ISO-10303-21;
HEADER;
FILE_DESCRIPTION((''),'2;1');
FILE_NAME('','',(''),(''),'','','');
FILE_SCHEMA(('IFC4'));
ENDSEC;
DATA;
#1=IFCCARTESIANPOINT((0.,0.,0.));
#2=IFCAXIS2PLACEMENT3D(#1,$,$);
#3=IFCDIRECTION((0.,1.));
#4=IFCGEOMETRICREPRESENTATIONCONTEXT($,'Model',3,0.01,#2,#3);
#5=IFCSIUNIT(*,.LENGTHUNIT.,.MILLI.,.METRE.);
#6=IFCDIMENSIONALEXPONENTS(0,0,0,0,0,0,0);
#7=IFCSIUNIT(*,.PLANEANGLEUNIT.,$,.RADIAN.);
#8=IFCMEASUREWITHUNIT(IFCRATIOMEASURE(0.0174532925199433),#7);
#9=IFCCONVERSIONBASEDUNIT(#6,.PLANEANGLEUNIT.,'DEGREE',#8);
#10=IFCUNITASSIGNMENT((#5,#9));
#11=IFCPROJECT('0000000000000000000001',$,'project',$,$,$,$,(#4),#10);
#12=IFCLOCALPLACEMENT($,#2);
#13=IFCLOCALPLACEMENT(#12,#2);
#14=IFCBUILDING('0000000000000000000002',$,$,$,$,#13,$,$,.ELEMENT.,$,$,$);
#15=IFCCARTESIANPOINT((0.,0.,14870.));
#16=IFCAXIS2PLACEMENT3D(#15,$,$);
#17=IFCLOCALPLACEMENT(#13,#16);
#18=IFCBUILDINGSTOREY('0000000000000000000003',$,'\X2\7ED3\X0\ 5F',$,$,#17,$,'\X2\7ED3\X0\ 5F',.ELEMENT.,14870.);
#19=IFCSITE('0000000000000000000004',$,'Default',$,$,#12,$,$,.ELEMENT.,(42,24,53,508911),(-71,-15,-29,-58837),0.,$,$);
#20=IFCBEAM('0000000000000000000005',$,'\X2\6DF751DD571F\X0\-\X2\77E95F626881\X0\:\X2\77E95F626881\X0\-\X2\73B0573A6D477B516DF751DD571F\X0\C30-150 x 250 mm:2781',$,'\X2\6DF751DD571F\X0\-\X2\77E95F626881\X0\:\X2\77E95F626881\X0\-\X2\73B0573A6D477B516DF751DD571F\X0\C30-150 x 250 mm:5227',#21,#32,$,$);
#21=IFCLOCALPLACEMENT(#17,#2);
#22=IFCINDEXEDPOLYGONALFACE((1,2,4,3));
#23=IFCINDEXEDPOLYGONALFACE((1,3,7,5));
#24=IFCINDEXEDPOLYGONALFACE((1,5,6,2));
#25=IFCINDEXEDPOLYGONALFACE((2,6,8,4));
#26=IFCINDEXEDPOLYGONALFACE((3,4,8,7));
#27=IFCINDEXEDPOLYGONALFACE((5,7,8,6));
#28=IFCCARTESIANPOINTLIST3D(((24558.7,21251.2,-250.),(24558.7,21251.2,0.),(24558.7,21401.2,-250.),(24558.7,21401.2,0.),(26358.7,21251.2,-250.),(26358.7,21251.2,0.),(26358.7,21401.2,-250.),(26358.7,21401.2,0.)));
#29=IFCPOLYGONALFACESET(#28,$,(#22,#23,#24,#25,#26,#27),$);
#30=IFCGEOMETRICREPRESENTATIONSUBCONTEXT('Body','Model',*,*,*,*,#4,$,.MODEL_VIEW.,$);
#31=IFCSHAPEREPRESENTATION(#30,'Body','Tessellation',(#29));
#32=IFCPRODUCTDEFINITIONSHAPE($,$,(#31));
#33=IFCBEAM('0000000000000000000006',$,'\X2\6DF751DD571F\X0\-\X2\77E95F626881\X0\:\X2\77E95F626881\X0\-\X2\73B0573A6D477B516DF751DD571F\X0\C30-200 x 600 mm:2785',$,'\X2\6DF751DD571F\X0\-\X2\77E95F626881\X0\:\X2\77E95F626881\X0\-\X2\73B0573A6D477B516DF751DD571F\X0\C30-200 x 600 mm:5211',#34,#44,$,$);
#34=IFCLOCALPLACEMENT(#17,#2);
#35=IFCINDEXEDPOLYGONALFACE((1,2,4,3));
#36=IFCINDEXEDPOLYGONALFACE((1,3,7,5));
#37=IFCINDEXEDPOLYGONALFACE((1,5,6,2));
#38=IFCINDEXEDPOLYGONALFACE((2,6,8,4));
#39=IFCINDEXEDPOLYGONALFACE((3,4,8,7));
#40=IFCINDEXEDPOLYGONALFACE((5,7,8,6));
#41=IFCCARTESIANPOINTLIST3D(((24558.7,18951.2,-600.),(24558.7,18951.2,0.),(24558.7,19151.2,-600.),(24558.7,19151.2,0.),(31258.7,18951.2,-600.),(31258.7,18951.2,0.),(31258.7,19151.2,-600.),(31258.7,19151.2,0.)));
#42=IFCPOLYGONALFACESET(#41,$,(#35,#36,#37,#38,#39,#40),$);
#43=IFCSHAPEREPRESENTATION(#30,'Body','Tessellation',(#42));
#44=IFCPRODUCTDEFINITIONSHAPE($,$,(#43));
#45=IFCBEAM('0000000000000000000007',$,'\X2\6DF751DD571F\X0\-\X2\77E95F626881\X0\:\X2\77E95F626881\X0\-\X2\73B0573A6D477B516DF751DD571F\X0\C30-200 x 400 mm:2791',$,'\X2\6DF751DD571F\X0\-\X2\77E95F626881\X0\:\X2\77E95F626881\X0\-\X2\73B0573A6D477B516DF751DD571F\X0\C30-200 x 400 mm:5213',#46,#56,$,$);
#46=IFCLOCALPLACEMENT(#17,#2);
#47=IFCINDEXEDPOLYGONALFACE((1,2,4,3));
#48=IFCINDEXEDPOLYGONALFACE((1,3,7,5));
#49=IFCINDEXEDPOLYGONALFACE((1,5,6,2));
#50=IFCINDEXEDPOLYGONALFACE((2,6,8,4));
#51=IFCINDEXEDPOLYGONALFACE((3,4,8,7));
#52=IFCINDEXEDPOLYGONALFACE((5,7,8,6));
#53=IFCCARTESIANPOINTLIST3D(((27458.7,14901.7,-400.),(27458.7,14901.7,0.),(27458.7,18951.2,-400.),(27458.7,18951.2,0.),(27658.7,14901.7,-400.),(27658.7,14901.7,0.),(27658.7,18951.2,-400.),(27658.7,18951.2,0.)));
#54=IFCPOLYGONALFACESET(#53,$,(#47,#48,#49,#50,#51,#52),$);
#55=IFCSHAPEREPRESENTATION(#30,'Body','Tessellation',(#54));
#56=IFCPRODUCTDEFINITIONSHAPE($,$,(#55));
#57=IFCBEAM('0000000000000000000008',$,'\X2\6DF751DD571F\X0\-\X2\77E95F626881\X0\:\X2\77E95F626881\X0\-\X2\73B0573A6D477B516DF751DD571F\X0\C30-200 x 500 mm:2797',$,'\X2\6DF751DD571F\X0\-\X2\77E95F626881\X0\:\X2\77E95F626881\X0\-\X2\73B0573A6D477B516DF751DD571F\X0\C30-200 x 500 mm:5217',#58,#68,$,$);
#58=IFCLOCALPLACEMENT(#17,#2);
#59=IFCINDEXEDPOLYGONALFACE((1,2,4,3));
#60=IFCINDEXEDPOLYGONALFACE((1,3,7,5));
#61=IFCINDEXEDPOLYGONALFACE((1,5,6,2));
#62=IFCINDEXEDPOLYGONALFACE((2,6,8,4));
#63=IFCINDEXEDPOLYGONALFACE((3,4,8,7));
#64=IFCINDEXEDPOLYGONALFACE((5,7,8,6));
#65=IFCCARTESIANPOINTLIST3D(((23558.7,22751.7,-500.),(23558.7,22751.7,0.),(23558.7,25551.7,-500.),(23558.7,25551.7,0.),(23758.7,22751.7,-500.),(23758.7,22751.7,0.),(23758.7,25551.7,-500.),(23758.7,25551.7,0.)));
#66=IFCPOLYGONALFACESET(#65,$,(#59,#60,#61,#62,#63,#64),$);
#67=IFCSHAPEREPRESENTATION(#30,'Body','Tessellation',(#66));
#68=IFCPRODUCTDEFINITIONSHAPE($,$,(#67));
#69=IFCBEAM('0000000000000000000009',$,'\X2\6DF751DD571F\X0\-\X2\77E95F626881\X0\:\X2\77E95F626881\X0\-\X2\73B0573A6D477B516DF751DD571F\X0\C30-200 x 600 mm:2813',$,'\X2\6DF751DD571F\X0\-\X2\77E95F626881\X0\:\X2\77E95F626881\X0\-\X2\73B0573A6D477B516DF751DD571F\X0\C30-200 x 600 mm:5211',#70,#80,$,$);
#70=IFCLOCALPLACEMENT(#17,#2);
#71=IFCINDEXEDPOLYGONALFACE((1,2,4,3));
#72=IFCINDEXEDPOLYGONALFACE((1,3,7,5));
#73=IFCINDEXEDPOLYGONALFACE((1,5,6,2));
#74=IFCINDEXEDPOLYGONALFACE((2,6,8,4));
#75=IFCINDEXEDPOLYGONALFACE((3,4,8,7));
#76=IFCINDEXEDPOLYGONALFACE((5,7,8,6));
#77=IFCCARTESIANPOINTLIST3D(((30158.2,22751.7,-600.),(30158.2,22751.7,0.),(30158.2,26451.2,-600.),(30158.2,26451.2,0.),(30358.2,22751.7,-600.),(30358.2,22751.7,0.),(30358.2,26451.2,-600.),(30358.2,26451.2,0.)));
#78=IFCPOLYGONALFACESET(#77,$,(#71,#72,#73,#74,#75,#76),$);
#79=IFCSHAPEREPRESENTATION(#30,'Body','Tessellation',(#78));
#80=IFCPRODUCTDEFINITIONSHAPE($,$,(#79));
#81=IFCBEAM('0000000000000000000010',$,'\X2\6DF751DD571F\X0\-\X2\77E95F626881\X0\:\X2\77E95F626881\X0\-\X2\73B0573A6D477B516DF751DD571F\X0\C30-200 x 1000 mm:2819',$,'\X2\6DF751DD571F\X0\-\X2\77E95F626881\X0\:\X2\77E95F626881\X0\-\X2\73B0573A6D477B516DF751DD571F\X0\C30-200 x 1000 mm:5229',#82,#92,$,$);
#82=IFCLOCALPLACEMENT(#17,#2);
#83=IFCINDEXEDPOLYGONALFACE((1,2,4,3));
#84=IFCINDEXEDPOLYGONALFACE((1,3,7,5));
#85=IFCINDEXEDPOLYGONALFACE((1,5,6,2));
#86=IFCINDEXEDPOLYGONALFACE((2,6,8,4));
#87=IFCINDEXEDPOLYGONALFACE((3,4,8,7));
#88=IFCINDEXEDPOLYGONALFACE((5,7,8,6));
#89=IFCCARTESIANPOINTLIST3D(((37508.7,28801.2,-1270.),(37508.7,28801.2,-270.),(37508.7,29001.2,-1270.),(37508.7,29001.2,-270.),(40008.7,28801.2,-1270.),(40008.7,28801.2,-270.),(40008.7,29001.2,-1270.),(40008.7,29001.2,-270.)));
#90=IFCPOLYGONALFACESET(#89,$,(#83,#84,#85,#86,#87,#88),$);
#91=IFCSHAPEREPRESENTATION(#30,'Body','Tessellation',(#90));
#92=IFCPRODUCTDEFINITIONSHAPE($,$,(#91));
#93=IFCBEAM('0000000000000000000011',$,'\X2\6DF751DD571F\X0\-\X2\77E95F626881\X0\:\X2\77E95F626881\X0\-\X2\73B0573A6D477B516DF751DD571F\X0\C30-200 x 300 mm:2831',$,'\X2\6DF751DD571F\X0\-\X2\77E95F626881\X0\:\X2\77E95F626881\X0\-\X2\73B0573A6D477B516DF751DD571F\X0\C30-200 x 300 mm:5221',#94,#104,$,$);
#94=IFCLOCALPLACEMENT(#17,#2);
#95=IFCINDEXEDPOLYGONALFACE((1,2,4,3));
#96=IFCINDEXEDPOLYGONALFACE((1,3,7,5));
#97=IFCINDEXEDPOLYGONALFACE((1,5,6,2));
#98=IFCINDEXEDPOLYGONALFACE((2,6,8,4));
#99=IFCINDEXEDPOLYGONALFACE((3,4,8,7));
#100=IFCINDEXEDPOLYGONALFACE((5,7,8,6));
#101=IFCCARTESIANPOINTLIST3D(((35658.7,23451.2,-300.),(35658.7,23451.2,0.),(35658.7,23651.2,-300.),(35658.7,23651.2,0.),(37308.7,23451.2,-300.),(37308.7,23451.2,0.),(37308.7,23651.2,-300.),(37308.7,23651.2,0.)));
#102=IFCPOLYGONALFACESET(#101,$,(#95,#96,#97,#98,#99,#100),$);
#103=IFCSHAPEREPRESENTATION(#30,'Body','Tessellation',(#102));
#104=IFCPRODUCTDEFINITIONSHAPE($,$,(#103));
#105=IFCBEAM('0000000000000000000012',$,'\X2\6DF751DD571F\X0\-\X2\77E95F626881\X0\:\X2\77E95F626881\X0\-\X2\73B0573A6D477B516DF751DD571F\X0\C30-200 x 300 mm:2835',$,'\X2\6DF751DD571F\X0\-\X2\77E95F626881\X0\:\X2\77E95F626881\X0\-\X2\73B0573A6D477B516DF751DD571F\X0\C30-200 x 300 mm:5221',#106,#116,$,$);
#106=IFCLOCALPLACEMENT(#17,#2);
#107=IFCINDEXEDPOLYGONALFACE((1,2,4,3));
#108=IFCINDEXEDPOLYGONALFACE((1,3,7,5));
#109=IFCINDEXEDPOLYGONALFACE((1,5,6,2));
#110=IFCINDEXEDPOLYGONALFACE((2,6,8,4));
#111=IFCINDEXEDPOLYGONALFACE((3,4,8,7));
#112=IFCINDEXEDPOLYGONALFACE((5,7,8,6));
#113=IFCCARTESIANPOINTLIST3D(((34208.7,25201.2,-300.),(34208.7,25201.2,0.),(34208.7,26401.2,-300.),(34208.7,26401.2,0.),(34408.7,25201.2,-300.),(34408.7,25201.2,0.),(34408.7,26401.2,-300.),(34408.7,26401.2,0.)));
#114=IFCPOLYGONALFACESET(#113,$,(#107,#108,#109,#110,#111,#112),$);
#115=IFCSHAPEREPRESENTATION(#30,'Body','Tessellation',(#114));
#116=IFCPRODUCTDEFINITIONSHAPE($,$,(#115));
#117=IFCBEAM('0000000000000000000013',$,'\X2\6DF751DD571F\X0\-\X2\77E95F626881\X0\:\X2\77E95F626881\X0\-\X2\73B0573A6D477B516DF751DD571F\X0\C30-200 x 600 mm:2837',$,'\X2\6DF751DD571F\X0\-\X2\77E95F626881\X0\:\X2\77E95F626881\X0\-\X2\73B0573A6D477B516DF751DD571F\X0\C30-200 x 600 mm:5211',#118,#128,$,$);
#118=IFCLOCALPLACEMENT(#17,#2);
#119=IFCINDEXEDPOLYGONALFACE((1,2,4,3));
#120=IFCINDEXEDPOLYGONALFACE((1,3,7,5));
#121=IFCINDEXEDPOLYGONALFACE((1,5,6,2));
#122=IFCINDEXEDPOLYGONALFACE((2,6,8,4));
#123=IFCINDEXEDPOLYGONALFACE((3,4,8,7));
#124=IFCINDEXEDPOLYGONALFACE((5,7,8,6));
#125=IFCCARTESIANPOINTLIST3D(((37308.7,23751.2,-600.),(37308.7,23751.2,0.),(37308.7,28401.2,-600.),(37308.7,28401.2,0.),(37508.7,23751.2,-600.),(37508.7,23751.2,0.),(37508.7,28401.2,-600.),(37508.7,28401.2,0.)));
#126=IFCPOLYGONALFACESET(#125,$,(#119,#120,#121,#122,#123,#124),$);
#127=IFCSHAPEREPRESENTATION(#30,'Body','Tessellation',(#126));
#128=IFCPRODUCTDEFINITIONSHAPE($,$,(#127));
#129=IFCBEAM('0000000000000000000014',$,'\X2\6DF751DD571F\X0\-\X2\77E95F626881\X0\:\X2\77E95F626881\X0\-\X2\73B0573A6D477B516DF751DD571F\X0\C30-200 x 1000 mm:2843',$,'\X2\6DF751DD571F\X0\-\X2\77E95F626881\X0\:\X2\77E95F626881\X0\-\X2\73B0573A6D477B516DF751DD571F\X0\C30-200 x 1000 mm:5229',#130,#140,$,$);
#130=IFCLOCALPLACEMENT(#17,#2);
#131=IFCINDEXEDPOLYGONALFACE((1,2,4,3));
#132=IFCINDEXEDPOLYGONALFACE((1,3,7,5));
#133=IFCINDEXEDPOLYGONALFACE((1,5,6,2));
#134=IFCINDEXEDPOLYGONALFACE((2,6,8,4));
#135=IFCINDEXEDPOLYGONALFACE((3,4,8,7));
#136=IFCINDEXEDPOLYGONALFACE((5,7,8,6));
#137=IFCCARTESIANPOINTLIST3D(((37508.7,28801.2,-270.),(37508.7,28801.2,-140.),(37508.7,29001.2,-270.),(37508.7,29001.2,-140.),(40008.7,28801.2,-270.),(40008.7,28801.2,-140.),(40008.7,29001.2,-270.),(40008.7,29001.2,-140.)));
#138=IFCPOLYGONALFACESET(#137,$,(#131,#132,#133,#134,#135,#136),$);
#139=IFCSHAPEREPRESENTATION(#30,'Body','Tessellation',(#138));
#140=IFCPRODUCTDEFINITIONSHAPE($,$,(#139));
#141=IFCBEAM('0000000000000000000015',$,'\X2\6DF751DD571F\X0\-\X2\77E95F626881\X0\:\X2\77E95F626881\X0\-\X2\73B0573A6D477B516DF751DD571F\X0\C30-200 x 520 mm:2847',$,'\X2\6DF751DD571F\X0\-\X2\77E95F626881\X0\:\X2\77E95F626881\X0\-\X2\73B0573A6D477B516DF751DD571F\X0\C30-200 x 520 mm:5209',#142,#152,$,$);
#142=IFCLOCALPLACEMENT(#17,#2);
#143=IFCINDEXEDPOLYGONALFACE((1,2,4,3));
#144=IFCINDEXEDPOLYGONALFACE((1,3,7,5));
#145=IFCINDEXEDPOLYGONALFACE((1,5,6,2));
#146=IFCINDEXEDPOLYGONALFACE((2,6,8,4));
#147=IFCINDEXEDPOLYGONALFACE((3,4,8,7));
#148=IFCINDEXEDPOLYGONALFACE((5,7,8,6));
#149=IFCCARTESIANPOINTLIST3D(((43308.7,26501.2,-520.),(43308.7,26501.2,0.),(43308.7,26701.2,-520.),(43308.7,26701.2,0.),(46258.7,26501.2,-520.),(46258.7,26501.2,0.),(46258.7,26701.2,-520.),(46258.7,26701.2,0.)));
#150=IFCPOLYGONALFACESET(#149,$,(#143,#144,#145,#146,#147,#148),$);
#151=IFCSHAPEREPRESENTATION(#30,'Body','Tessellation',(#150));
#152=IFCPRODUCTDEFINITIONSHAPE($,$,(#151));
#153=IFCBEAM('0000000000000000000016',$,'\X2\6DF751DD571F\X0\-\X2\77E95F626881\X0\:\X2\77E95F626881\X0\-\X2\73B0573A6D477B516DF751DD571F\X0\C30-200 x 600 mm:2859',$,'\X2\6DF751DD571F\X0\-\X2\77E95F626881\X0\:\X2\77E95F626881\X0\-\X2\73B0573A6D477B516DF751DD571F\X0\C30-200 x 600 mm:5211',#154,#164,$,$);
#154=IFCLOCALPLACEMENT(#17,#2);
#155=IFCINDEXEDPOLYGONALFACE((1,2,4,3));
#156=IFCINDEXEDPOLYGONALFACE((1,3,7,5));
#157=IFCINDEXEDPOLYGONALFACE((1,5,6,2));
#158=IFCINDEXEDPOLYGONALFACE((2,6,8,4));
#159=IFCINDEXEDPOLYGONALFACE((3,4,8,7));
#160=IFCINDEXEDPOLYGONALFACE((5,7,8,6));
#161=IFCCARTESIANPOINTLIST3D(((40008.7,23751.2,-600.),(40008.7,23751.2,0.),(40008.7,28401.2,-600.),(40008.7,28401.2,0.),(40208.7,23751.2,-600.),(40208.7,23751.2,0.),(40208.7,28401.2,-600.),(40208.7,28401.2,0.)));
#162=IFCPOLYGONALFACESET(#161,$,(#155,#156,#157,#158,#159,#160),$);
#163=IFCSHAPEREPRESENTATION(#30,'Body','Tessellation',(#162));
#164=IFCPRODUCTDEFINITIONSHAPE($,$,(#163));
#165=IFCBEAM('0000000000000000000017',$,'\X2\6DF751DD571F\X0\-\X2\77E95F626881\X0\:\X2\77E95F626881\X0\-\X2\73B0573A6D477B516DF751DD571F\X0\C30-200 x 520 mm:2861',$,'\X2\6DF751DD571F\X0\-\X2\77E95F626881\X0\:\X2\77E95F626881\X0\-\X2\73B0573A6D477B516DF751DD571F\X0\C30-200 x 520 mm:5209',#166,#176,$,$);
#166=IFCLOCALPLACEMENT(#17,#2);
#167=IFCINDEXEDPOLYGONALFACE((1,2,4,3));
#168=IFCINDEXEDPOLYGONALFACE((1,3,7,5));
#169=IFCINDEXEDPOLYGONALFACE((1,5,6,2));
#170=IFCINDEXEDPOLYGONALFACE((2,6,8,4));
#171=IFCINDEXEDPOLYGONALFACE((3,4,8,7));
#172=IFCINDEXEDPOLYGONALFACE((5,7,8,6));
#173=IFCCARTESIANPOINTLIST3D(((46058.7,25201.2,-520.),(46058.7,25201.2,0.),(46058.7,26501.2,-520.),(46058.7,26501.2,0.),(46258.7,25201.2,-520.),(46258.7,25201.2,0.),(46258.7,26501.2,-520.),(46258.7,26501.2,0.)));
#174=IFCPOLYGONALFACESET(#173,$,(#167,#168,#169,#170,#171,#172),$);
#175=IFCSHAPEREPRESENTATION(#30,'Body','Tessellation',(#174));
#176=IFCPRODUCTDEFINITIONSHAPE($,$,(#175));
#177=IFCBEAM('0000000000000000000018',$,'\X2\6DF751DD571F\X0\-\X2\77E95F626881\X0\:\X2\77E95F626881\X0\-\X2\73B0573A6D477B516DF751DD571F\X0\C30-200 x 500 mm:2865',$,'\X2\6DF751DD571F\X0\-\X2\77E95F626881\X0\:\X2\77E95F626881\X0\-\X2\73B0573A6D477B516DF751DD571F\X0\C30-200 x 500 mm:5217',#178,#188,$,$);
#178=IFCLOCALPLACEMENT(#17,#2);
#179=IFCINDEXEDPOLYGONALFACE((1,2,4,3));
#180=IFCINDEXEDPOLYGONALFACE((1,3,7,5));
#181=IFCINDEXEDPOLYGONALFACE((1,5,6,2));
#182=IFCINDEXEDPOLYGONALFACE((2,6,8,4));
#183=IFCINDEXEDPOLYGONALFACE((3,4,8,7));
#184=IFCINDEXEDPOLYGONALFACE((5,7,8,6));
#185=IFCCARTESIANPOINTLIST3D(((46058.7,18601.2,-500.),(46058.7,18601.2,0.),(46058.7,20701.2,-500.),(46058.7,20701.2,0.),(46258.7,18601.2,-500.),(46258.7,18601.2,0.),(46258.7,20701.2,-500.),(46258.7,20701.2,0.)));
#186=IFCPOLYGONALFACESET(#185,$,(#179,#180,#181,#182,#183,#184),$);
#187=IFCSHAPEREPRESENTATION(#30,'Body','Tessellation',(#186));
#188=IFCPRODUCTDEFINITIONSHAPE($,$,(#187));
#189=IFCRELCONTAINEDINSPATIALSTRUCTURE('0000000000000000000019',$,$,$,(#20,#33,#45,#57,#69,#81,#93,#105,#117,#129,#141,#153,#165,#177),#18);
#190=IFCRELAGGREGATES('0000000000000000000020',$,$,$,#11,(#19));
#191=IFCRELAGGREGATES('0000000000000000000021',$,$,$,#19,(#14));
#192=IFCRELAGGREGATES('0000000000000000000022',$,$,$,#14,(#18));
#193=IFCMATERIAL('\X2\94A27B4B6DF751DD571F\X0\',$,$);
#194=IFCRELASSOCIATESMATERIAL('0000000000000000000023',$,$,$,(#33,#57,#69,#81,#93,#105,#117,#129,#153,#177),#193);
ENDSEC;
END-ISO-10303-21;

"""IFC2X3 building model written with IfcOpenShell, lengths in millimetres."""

from ifc_helpers import new_model, entity, si_unit, converted_unit, direction, frame, frame_2d, origin, place, context, subcontext, project, spatial, rectangle, extrude, material, element, save


model = new_model("IFC2X3")

# Units and contexts
model_context = context("Model", 3, precision=0.01, world=origin(), true_north=direction((0.0, 1.0)))
body_context = subcontext(model_context, "Body", "Model", "MODEL_VIEW")
ifc_project = project(units=[si_unit("LENGTHUNIT", "METRE", prefix="MILLI"), converted_unit("PLANEANGLEUNIT", "DEGREE", entity("IfcRatioMeasure", 0.0174532925199433), si_unit("PLANEANGLEUNIT", "RADIAN"), dimensions=[0, 0, 0, 0, 0, 0, 0])], contexts=[model_context])

# Site, building, storey
site_placement = place(None, origin())
site = spatial("IfcSite", under=ifc_project, at=site_placement, Name="Default", CompositionType="ELEMENT", RefLatitude=(42, 24, 53, 508911), RefLongitude=(-71, -15, -29, -58837), RefElevation=0.0)
building_placement = place(site_placement, origin())
building = spatial("IfcBuilding", under=site, at=building_placement, CompositionType="ELEMENT")
storey_placement = place(building_placement, frame((0.0, 0.0, 14870.0)))
storey = spatial("IfcBuildingStorey", under=building, at=storey_placement, Name="结 5F", LongName="结 5F", CompositionType="ELEMENT", Elevation=14870.0)

# Beams
beam_1_placement = place(storey_placement, frame((26433.7, 21326.2, 0.0), z_axis=(0.0, 0.0, 1.0), x_axis=(-1.0, 0.0, 0.0)))
element("IfcBeam", 1, at=beam_1_placement, inside=storey, Name="混凝土-矩形梁:矩形梁-现场浇筑混凝土C30-150 x 250 mm:2781", ObjectType="混凝土-矩形梁:矩形梁-现场浇筑混凝土C30-150 x 250 mm:5227", context=body_context, shape_type="SweptSolid", body=[
    extrude(rectangle(XDim=250.0, YDim=150.0, at=frame_2d((0.0, 0.0), x_axis=(1.0, 0.0))), frame((75.0, 0.0, -125.0), z_axis=(1.0, 0.0, 0.0), x_axis=(0.0, 0.0, -1.0)), (0.0, 0.0, 1.0), 1800.0),
])
ifc_material = material(Name="钢筋混凝土")
beam_2_placement = place(storey_placement, frame((31358.7, 19051.2, 0.0), z_axis=(0.0, 0.0, 1.0), x_axis=(-1.0, 0.0, 0.0)))
element("IfcBeam", 2, at=beam_2_placement, inside=storey, material=ifc_material, Name="混凝土-矩形梁:矩形梁-现场浇筑混凝土C30-200 x 600 mm:2785", ObjectType="混凝土-矩形梁:矩形梁-现场浇筑混凝土C30-200 x 600 mm:5211", context=body_context, shape_type="SweptSolid", body=[
    extrude(rectangle(XDim=600.0, YDim=200.0, at=frame_2d((0.0, 0.0), x_axis=(1.0, 0.0))), frame((100.0, 0.0, -300.0), z_axis=(1.0, 0.0, 0.0), x_axis=(0.0, 0.0, -1.0)), (0.0, 0.0, 1.0), 6700.0),
])
beam_3_placement = place(storey_placement, frame((27558.7, 14801.7, 0.0), z_axis=(0.0, 0.0, 1.0), x_axis=(0.0, 1.0, 0.0)))
element("IfcBeam", 3, at=beam_3_placement, inside=storey, Name="混凝土-矩形梁:矩形梁-现场浇筑混凝土C30-200 x 400 mm:2791", ObjectType="混凝土-矩形梁:矩形梁-现场浇筑混凝土C30-200 x 400 mm:5213", context=body_context, shape_type="SweptSolid", body=[
    extrude(rectangle(XDim=400.0, YDim=200.0, at=frame_2d((0.0, 0.0), x_axis=(1.0, 0.0))), frame((100.0, 0.0, -200.0), z_axis=(1.0, 0.0, 0.0), x_axis=(0.0, 0.0, -1.0)), (0.0, 0.0, 1.0), 4049.5),
])
beam_4_placement = place(storey_placement, frame((23658.7, 22651.7, 0.0), z_axis=(0.0, 0.0, 1.0), x_axis=(0.0, 1.0, 0.0)))
element("IfcBeam", 4, at=beam_4_placement, inside=storey, material=ifc_material, Name="混凝土-矩形梁:矩形梁-现场浇筑混凝土C30-200 x 500 mm:2797", ObjectType="混凝土-矩形梁:矩形梁-现场浇筑混凝土C30-200 x 500 mm:5217", context=body_context, shape_type="SweptSolid", body=[
    extrude(rectangle(XDim=500.0, YDim=200.0, at=frame_2d((0.0, 0.0), x_axis=(1.0, 0.0))), frame((100.0, 0.0, -250.0), z_axis=(1.0, 0.0, 0.0), x_axis=(0.0, 0.0, -1.0)), (0.0, 0.0, 1.0), 2800.0),
])
beam_5_placement = place(storey_placement, frame((30258.2, 22651.7, 0.0), z_axis=(0.0, 0.0, 1.0), x_axis=(0.0, 1.0, 0.0)))
element("IfcBeam", 5, at=beam_5_placement, inside=storey, material=ifc_material, Name="混凝土-矩形梁:矩形梁-现场浇筑混凝土C30-200 x 600 mm:2813", ObjectType="混凝土-矩形梁:矩形梁-现场浇筑混凝土C30-200 x 600 mm:5211", context=body_context, shape_type="SweptSolid", body=[
    extrude(rectangle(XDim=600.0, YDim=200.0, at=frame_2d((0.0, 0.0), x_axis=(1.0, 0.0))), frame((100.0, 0.0, -300.0), z_axis=(1.0, 0.0, 0.0), x_axis=(0.0, 0.0, -1.0)), (0.0, 0.0, 1.0), 3699.5),
])
beam_6_placement = place(storey_placement, frame((36458.7, 28901.2, -270.0)))
element("IfcBeam", 6, at=beam_6_placement, inside=storey, material=ifc_material, Name="混凝土-矩形梁:矩形梁-现场浇筑混凝土C30-200 x 1000 mm:2819", ObjectType="混凝土-矩形梁:矩形梁-现场浇筑混凝土C30-200 x 1000 mm:5229", context=body_context, shape_type="SweptSolid", body=[
    extrude(rectangle(XDim=1000.0, YDim=200.0, at=frame_2d((0.0, 0.0), x_axis=(1.0, 0.0))), frame((1050.0, 0.0, -500.0), z_axis=(1.0, 0.0, 0.0), x_axis=(0.0, 0.0, -1.0)), (0.0, 0.0, 1.0), 2500.0),
])
beam_7_placement = place(storey_placement, frame((35558.7, 23551.2, 0.0)))
element("IfcBeam", 7, at=beam_7_placement, inside=storey, material=ifc_material, Name="混凝土-矩形梁:矩形梁-现场浇筑混凝土C30-200 x 300 mm:2831", ObjectType="混凝土-矩形梁:矩形梁-现场浇筑混凝土C30-200 x 300 mm:5221", context=body_context, shape_type="SweptSolid", body=[
    extrude(rectangle(XDim=300.0, YDim=200.0, at=frame_2d((0.0, 0.0), x_axis=(1.0, 0.0))), frame((100.0, 0.0, -150.0), z_axis=(1.0, 0.0, 0.0), x_axis=(0.0, 0.0, -1.0)), (0.0, 0.0, 1.0), 1650.0),
])
beam_8_placement = place(storey_placement, frame((34308.7, 25101.2, 0.0), z_axis=(0.0, 0.0, 1.0), x_axis=(0.0, 1.0, 0.0)))
element("IfcBeam", 8, at=beam_8_placement, inside=storey, material=ifc_material, Name="混凝土-矩形梁:矩形梁-现场浇筑混凝土C30-200 x 300 mm:2835", ObjectType="混凝土-矩形梁:矩形梁-现场浇筑混凝土C30-200 x 300 mm:5221", context=body_context, shape_type="SweptSolid", body=[
    extrude(rectangle(XDim=300.0, YDim=200.0, at=frame_2d((0.0, 0.0), x_axis=(1.0, 0.0))), frame((100.0, 0.0, -150.0), z_axis=(1.0, 0.0, 0.0), x_axis=(0.0, 0.0, -1.0)), (0.0, 0.0, 1.0), 1200.0),
])
beam_9_placement = place(storey_placement, frame((37408.7, 23551.2, 0.0), z_axis=(0.0, 0.0, 1.0), x_axis=(0.0, 1.0, 0.0)))
element("IfcBeam", 9, at=beam_9_placement, inside=storey, material=ifc_material, Name="混凝土-矩形梁:矩形梁-现场浇筑混凝土C30-200 x 600 mm:2837", ObjectType="混凝土-矩形梁:矩形梁-现场浇筑混凝土C30-200 x 600 mm:5211", context=body_context, shape_type="SweptSolid", body=[
    extrude(rectangle(XDim=600.0, YDim=200.0, at=frame_2d((0.0, 0.0), x_axis=(1.0, 0.0))), frame((200.0, 0.0, -300.0), z_axis=(1.0, 0.0, 0.0), x_axis=(0.0, 0.0, -1.0)), (0.0, 0.0, 1.0), 4650.0),
])
beam_10_placement = place(storey_placement, frame((41058.7, 28901.2, -140.0), z_axis=(0.0, 0.0, 1.0), x_axis=(-1.0, 0.0, 0.0)))
element("IfcBeam", 10, at=beam_10_placement, inside=storey, material=ifc_material, Name="混凝土-矩形梁:矩形梁-现场浇筑混凝土C30-200 x 1000 mm:2843", ObjectType="混凝土-矩形梁:矩形梁-现场浇筑混凝土C30-200 x 1000 mm:5229", context=body_context, shape_type="SweptSolid", body=[
    extrude(rectangle(XDim=130.0, YDim=200.0, at=frame_2d((0.0, 0.0), x_axis=(1.0, 0.0))), frame((1050.0, 0.0, -65.0), z_axis=(1.0, 0.0, 0.0), x_axis=(0.0, 0.0, -1.0)), (0.0, 0.0, 1.0), 2500.0),
])
beam_11_placement = place(storey_placement, frame((46158.7, 26601.2, 0.0), z_axis=(0.0, 0.0, 1.0), x_axis=(-1.0, 0.0, 0.0)))
element("IfcBeam", 11, at=beam_11_placement, inside=storey, Name="混凝土-矩形梁:矩形梁-现场浇筑混凝土C30-200 x 520 mm:2847", ObjectType="混凝土-矩形梁:矩形梁-现场浇筑混凝土C30-200 x 520 mm:5209", context=body_context, shape_type="SweptSolid", body=[
    extrude(rectangle(XDim=520.0, YDim=200.0, at=frame_2d((0.0, 0.0), x_axis=(1.0, 0.0))), frame((-100.0, 0.0, -260.0), z_axis=(1.0, 0.0, 0.0), x_axis=(0.0, 0.0, -1.0)), (0.0, 0.0, 1.0), 2950.0),
])
beam_12_placement = place(storey_placement, frame((40108.7, 23551.2, 0.0), z_axis=(0.0, 0.0, 1.0), x_axis=(0.0, 1.0, 0.0)))
element("IfcBeam", 12, at=beam_12_placement, inside=storey, material=ifc_material, Name="混凝土-矩形梁:矩形梁-现场浇筑混凝土C30-200 x 600 mm:2859", ObjectType="混凝土-矩形梁:矩形梁-现场浇筑混凝土C30-200 x 600 mm:5211", context=body_context, shape_type="SweptSolid", body=[
    extrude(rectangle(XDim=600.0, YDim=200.0, at=frame_2d((0.0, 0.0), x_axis=(1.0, 0.0))), frame((200.0, 0.0, -300.0), z_axis=(1.0, 0.0, 0.0), x_axis=(0.0, 0.0, -1.0)), (0.0, 0.0, 1.0), 4650.0),
])
beam_13_placement = place(storey_placement, frame((46158.7, 26601.2, 0.0), z_axis=(0.0, 0.0, 1.0), x_axis=(0.0, -1.0, 0.0)))
element("IfcBeam", 13, at=beam_13_placement, inside=storey, Name="混凝土-矩形梁:矩形梁-现场浇筑混凝土C30-200 x 520 mm:2861", ObjectType="混凝土-矩形梁:矩形梁-现场浇筑混凝土C30-200 x 520 mm:5209", context=body_context, shape_type="SweptSolid", body=[
    extrude(rectangle(XDim=520.0, YDim=200.0, at=frame_2d((0.0, 0.0), x_axis=(1.0, 0.0))), frame((100.0, 0.0, -260.0), z_axis=(1.0, 0.0, 0.0), x_axis=(0.0, 0.0, -1.0)), (0.0, 0.0, 1.0), 1300.0),
])
beam_14_placement = place(storey_placement, frame((46158.7, 21201.2, 0.0), z_axis=(0.0, 0.0, 1.0), x_axis=(0.0, -1.0, 0.0)))
element("IfcBeam", 14, at=beam_14_placement, inside=storey, material=ifc_material, Name="混凝土-矩形梁:矩形梁-现场浇筑混凝土C30-200 x 500 mm:2865", ObjectType="混凝土-矩形梁:矩形梁-现场浇筑混凝土C30-200 x 500 mm:5217", context=body_context, shape_type="SweptSolid", body=[
    extrude(rectangle(XDim=500.0, YDim=200.0, at=frame_2d((0.0, 0.0), x_axis=(1.0, 0.0))), frame((500.0, 0.0, -250.0), z_axis=(1.0, 0.0, 0.0), x_axis=(0.0, 0.0, -1.0)), (0.0, 0.0, 1.0), 2100.0),
])

save(model, "model.ifc")
